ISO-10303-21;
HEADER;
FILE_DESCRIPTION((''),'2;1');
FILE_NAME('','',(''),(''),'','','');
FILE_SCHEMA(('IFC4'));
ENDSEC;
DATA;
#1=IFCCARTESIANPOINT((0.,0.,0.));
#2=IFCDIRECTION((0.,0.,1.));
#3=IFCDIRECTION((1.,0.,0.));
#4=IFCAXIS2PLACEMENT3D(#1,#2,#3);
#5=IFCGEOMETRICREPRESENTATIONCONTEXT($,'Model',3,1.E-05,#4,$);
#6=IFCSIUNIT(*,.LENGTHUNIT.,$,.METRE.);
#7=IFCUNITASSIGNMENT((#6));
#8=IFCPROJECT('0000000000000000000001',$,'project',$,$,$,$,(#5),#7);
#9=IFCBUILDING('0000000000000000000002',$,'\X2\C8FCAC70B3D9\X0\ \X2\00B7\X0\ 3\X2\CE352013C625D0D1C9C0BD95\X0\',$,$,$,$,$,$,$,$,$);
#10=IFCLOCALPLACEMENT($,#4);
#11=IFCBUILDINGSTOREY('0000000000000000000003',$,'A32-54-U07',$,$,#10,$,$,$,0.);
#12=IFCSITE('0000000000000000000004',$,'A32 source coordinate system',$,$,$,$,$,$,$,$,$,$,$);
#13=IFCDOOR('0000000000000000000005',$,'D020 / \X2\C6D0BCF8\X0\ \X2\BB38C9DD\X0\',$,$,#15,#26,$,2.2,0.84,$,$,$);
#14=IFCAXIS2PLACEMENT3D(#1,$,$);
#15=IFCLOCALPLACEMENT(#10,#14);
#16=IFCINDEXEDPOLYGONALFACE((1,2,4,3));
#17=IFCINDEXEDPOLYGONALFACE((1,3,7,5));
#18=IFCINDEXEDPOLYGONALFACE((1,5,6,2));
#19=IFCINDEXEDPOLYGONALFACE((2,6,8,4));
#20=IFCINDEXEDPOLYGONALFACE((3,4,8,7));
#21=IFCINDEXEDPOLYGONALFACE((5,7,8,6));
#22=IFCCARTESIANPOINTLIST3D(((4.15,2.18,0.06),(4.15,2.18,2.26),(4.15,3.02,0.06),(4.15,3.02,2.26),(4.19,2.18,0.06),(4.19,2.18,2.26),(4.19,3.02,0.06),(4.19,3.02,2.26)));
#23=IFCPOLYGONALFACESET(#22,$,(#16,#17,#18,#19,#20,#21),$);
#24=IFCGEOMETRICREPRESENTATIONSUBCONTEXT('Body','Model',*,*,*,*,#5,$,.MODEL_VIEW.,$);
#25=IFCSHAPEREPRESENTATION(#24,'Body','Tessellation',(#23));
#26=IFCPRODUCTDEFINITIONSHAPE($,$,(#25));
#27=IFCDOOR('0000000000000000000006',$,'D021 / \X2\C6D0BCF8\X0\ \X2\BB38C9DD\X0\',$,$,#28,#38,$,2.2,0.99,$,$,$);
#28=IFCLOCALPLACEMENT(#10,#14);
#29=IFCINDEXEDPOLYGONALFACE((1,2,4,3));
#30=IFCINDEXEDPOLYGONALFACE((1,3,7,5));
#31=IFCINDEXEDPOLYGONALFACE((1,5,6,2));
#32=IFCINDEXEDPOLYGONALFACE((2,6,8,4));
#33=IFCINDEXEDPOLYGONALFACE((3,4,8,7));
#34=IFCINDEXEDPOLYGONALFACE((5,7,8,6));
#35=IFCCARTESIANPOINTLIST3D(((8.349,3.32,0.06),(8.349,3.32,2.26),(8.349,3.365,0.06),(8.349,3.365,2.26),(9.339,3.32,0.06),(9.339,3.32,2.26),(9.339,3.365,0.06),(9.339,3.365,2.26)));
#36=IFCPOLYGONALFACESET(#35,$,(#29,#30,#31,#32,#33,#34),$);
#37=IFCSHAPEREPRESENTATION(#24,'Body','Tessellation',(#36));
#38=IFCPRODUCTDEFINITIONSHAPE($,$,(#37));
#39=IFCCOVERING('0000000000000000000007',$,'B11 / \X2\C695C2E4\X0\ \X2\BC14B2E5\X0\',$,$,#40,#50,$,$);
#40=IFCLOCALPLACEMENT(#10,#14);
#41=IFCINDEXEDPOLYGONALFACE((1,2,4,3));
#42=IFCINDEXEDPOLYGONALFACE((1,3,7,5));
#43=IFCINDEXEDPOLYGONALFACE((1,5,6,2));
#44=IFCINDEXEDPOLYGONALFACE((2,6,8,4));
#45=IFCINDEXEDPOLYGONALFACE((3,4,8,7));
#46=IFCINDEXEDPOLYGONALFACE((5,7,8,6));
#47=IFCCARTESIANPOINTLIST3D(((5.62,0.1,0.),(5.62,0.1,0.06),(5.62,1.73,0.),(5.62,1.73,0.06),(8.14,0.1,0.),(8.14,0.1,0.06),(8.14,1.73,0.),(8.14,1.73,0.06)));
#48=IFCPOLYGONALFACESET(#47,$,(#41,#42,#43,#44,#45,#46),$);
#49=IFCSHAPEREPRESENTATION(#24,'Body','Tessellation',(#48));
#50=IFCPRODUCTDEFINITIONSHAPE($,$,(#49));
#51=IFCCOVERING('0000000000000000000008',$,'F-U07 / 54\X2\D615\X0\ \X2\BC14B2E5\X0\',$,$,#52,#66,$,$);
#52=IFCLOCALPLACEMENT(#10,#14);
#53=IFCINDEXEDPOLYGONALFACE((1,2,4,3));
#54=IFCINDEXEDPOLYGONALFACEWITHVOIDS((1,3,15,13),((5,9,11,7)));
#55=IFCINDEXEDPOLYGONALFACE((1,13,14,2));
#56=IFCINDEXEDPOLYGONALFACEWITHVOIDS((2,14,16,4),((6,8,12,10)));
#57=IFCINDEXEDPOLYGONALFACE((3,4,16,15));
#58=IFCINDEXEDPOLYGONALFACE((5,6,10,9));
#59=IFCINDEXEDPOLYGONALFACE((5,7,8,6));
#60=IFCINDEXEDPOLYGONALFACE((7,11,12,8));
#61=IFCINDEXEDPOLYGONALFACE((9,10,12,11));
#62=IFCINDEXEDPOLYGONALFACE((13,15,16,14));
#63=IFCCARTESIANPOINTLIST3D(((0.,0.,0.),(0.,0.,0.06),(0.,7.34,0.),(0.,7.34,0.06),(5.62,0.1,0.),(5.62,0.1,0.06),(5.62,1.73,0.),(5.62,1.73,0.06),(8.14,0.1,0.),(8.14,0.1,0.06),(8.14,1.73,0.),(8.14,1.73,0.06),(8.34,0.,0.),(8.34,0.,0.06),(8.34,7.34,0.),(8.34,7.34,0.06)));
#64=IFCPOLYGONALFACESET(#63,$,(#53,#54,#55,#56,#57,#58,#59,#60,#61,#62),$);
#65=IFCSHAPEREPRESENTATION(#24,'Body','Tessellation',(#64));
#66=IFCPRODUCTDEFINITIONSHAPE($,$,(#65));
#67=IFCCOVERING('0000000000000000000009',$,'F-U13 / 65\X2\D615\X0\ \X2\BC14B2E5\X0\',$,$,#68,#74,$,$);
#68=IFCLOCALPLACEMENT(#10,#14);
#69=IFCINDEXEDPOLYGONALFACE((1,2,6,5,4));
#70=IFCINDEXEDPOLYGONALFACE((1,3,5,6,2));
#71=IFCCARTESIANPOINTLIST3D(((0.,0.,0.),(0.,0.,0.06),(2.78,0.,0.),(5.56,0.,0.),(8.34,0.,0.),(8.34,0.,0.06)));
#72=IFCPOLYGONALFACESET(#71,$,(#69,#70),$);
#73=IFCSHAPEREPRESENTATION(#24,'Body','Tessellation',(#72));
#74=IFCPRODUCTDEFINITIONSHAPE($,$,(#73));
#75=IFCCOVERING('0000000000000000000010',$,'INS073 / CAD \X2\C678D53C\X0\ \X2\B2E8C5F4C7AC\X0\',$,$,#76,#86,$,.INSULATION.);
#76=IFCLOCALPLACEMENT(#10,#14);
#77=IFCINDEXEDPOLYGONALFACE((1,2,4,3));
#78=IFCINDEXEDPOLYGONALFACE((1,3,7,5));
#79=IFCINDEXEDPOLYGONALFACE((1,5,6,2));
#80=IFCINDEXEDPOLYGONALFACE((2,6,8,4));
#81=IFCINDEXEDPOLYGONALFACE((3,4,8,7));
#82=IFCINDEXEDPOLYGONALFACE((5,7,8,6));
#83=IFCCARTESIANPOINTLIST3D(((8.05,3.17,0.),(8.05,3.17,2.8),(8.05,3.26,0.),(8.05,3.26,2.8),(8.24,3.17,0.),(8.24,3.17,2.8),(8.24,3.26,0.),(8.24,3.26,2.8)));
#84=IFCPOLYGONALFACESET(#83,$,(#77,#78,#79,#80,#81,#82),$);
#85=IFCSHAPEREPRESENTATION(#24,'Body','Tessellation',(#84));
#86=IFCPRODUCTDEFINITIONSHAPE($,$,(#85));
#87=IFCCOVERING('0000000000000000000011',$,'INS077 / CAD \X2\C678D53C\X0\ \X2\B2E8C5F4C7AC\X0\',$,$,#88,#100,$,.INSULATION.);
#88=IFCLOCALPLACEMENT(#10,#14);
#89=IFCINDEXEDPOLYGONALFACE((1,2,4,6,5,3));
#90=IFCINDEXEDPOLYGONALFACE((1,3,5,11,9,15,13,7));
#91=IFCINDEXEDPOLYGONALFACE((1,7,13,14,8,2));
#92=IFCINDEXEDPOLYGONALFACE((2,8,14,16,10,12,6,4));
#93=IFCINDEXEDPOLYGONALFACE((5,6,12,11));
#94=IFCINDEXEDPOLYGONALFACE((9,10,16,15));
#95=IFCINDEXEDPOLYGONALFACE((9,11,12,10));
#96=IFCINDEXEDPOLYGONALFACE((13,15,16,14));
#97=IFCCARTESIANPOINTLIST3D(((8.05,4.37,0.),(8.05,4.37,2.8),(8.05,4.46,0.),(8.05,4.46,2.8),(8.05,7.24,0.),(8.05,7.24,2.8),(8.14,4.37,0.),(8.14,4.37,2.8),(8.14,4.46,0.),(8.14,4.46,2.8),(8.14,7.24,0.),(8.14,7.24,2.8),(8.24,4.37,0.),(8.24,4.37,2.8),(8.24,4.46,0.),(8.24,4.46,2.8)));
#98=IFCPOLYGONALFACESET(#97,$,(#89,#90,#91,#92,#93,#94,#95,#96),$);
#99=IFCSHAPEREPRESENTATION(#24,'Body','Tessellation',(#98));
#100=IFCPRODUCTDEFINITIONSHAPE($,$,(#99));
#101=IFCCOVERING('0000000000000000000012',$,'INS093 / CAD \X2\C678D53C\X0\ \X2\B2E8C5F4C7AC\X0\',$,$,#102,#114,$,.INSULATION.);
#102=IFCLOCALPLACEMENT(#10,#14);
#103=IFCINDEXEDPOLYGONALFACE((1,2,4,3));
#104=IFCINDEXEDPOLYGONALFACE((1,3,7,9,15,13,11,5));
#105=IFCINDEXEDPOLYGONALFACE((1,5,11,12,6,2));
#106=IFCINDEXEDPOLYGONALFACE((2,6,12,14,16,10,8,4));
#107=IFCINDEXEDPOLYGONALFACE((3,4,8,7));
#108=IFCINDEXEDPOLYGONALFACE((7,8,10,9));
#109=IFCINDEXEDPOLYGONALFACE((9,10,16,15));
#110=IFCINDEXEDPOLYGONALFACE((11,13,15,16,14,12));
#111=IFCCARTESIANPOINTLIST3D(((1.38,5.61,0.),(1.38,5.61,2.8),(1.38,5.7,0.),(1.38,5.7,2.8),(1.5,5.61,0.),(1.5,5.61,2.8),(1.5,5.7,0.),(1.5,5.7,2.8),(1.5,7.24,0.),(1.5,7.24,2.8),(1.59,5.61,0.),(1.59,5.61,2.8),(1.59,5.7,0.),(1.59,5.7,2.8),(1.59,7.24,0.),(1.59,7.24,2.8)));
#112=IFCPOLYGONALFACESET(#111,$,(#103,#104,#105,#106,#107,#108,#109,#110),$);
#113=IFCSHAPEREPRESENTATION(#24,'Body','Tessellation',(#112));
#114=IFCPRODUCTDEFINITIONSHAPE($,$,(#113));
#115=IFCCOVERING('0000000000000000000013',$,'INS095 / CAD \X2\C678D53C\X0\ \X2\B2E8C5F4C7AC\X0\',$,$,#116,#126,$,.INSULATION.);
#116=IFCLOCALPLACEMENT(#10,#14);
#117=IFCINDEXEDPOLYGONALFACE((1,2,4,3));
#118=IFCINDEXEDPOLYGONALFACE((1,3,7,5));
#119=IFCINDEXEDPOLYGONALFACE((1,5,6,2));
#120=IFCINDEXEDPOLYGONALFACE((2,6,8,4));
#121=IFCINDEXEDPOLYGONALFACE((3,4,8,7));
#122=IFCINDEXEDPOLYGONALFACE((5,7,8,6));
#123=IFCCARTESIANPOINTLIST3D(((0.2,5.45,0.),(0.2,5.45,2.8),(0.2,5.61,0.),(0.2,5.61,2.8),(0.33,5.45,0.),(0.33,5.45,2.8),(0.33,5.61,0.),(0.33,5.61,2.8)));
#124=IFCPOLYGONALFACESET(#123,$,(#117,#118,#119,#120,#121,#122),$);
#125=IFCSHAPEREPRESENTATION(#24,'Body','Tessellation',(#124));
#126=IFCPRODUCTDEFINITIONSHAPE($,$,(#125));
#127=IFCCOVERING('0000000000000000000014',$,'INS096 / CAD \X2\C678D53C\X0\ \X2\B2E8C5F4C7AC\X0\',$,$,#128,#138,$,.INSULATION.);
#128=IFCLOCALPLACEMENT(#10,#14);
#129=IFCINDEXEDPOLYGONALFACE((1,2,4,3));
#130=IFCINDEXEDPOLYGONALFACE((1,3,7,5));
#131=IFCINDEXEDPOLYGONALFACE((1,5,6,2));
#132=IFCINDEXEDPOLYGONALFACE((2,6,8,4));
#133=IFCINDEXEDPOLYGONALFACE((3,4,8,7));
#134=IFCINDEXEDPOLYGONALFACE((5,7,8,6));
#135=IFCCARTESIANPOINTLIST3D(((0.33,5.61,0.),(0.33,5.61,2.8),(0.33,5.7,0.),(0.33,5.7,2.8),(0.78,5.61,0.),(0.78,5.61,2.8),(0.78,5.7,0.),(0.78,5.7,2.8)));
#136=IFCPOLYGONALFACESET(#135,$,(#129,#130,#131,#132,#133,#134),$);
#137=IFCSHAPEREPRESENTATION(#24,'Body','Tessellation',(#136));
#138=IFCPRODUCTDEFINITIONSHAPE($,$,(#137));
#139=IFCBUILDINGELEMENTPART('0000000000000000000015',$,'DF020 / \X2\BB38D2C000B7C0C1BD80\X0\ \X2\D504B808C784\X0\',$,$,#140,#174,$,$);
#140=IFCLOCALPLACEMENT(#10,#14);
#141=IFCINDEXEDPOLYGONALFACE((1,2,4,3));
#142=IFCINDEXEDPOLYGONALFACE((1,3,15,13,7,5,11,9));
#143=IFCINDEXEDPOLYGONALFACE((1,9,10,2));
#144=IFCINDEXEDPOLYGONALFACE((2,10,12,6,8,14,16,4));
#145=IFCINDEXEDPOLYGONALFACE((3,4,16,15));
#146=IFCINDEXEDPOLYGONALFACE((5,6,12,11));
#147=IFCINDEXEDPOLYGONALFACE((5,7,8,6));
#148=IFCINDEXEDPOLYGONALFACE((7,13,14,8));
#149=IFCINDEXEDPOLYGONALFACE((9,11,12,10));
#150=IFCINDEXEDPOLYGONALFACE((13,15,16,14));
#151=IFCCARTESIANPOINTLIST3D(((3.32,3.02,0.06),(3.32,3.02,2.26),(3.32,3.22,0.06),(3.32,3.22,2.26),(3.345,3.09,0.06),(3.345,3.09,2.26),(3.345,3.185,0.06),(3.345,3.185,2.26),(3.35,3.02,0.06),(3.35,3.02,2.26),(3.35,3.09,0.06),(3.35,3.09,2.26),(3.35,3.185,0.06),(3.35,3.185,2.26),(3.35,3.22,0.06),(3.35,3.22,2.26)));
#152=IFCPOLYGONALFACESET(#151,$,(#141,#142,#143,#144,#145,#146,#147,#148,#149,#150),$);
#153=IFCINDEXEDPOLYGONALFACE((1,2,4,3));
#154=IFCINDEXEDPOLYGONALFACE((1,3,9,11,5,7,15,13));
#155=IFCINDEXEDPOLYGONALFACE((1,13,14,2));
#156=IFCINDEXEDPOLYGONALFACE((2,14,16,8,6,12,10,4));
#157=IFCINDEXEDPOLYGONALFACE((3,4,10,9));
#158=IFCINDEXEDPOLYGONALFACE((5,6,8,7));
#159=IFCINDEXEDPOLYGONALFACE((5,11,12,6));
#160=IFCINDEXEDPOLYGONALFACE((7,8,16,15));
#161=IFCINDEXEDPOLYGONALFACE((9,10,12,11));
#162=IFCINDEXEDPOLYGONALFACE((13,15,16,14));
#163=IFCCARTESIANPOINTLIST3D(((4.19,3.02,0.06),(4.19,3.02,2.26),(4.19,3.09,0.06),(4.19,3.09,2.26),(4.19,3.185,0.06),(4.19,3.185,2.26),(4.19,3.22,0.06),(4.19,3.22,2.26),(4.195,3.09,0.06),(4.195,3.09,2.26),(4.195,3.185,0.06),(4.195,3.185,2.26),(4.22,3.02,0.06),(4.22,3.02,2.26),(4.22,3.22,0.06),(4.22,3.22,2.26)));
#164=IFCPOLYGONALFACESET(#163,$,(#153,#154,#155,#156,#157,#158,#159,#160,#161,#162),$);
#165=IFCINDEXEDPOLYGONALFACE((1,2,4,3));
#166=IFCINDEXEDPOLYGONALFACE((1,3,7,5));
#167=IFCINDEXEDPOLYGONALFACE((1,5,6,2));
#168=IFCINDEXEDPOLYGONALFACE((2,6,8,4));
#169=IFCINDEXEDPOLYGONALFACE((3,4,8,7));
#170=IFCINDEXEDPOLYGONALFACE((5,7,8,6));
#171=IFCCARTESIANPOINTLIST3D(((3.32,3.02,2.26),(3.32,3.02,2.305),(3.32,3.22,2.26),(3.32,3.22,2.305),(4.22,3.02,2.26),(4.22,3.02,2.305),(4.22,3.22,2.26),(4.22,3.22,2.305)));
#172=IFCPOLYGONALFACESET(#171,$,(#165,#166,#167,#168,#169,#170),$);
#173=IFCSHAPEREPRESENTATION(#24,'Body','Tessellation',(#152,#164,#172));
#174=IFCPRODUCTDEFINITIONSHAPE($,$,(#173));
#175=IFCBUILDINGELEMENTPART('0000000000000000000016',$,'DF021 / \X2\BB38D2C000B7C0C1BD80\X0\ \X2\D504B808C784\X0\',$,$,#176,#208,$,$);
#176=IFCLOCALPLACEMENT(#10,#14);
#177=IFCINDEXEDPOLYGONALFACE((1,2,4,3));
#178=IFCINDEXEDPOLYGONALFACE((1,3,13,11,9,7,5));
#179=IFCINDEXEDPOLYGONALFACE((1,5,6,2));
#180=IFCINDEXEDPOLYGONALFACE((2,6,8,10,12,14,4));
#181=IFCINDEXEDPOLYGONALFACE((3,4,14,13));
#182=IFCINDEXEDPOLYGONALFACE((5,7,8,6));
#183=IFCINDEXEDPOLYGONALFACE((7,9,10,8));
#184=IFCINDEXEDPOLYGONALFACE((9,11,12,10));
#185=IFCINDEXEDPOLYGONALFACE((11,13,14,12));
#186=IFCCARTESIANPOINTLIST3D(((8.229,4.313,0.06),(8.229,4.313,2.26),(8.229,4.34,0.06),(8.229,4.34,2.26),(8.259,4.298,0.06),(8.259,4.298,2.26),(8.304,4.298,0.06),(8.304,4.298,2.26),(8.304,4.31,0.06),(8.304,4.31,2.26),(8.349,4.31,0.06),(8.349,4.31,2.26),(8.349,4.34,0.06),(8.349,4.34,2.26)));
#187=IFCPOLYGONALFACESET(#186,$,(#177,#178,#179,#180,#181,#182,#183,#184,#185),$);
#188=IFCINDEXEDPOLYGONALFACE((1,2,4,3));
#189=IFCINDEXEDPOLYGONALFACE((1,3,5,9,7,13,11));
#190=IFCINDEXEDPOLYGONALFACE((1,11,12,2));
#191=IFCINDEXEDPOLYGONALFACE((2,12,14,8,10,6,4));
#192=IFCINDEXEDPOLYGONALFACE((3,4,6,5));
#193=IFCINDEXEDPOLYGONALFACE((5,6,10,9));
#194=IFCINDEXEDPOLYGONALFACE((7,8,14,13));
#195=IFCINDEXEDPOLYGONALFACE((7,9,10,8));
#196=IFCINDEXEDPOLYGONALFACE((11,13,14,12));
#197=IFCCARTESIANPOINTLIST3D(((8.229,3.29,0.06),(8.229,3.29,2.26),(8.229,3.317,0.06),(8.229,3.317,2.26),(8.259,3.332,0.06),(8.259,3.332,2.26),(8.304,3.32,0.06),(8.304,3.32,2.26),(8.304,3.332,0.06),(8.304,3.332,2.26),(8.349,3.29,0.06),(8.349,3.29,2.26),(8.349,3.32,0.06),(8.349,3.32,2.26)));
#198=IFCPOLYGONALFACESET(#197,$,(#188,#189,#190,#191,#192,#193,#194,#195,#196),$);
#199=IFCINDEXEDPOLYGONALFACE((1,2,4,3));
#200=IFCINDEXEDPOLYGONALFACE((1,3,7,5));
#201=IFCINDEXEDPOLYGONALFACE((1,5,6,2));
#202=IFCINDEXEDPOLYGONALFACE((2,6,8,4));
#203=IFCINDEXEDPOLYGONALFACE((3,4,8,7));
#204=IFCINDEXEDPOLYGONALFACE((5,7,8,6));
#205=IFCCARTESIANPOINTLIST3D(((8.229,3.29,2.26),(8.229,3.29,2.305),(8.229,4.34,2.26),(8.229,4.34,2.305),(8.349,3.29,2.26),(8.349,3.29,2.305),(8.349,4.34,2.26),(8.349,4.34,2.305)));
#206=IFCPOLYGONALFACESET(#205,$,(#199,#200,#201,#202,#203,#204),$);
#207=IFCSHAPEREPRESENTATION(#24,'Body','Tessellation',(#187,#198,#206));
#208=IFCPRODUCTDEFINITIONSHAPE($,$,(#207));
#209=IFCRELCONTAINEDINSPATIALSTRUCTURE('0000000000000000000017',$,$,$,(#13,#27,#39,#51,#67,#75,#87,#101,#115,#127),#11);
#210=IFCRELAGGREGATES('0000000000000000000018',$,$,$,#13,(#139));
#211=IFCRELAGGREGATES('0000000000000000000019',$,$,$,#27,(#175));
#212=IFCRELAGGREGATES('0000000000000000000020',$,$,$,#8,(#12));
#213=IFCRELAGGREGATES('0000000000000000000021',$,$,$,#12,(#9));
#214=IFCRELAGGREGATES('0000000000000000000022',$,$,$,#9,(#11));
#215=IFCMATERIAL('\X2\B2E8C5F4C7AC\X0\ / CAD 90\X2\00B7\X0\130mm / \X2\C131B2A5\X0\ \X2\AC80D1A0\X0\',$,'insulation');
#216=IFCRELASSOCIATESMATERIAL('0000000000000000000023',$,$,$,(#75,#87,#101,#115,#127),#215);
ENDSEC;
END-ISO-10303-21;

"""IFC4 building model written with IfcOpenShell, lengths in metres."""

from ifc_helpers import new_model, si_unit, frame, origin, origin_with_axes, place, context, subcontext, project, spatial, polyline, outline, extrude, material, element, aggregate, save


model = new_model("IFC4")

# Units and contexts
model_context = context("Model", 3, precision=1e-05, world=origin_with_axes())
body_context = subcontext(model_context, "Body", "Model", "MODEL_VIEW")
ifc_project = project(units=[si_unit("LENGTHUNIT", "METRE")], contexts=[model_context])

# Site, building, storey
storey_placement = place(None, origin_with_axes())
site = spatial("IfcSite", under=ifc_project, Name="A32 source coordinate system")
building = spatial("IfcBuilding", under=site, Name="주거동 · 3층–옥탑지붕")
storey = spatial("IfcBuildingStorey", under=building, at=storey_placement, Name="A32-54-U07", Elevation=0.0)

# Doors
door_1_placement = place(storey_placement, origin_with_axes())
door_1 = element("IfcDoor", 1, at=door_1_placement, inside=storey, Name="D020 / 원본 문짝", OverallHeight=2.2, OverallWidth=0.84, context=body_context, shape_type="SweptSolid", body=[
    extrude(outline(polyline([(4.19, 3.02), (4.19, 2.18), (4.15, 2.18), (4.15, 3.02), (4.19, 3.02)])), frame((0.0, 0.0, 0.06)), (0.0, 0.0, 1.0), 2.2),
])
door_2_placement = place(storey_placement, origin_with_axes())
door_2 = element("IfcDoor", 2, at=door_2_placement, inside=storey, Name="D021 / 원본 문짝", OverallHeight=2.2, OverallWidth=0.99, context=body_context, shape_type="SweptSolid", body=[
    extrude(outline(polyline([(9.339, 3.365), (9.339, 3.32), (8.349, 3.32), (8.349, 3.365), (9.339, 3.365)])), frame((0.0, 0.0, 0.06)), (0.0, 0.0, 1.0), 2.2),
])

# Coverings
covering_1_placement = place(storey_placement, origin_with_axes())
element("IfcCovering", 3, at=covering_1_placement, inside=storey, Name="B11 / 욕실 바닥", context=body_context, shape_type="SweptSolid", body=[
    extrude(outline(polyline([(8.14, 1.73), (8.14, 0.1), (5.62, 0.1), (5.62, 1.73), (8.14, 1.73)])), origin(), (0.0, 0.0, 1.0), 0.06),
])
covering_2_placement = place(storey_placement, origin_with_axes())
element("IfcCovering", 4, at=covering_2_placement, inside=storey, Name="F-U07 / 54형 바닥", context=body_context, shape_type="SweptSolid", body=[
    extrude(outline(polyline([(0.0, 0.0), (0.0, 7.34), (8.34, 7.34), (8.34, 0.0), (0.0, 0.0)]), holes=[polyline([(5.62, 1.73), (5.62, 0.1), (8.14, 0.1), (8.14, 1.73), (5.62, 1.73)])]), origin(), (0.0, 0.0, 1.0), 0.06),
])
covering_3_placement = place(storey_placement, origin_with_axes())
element("IfcCovering", 5, at=covering_3_placement, inside=storey, Name="F-U13 / 65형 바닥", context=body_context, shape_type="SweptSolid", body=[
    extrude(outline(polyline([(0.0, 0.0), (8.34, 0.0), (8.34, 0.0), (0.0, 0.0), (0.0, 0.0)])), origin(), (0.0, 0.0, 1.0), 0.06),
])
ifc_material = material(Name="단열재 / CAD 90·130mm / 성능 검토", Category="insulation")
covering_4_placement = place(storey_placement, origin_with_axes())
element("IfcCovering", 6, at=covering_4_placement, inside=storey, material=ifc_material, Name="INS073 / CAD 외피 단열재", PredefinedType="INSULATION", context=body_context, shape_type="SweptSolid", body=[
    extrude(outline(polyline([(8.05, 3.17), (8.05, 3.26), (8.24, 3.26), (8.24, 3.17), (8.05, 3.17)])), origin(), (0.0, 0.0, 1.0), 2.8),
])
covering_5_placement = place(storey_placement, origin_with_axes())
element("IfcCovering", 7, at=covering_5_placement, inside=storey, material=ifc_material, Name="INS077 / CAD 외피 단열재", PredefinedType="INSULATION", context=body_context, shape_type="SweptSolid", body=[
    extrude(outline(polyline([(8.24, 4.37), (8.14, 4.37), (8.05, 4.37), (8.05, 4.46), (8.05, 7.24), (8.14, 7.24), (8.14, 4.46), (8.24, 4.46), (8.24, 4.37)])), origin(), (0.0, 0.0, 1.0), 2.8),
])
covering_6_placement = place(storey_placement, origin_with_axes())
element("IfcCovering", 8, at=covering_6_placement, inside=storey, material=ifc_material, Name="INS093 / CAD 외피 단열재", PredefinedType="INSULATION", context=body_context, shape_type="SweptSolid", body=[
    extrude(outline(polyline([(1.5, 5.7), (1.5, 7.24), (1.59, 7.24), (1.59, 5.7), (1.59, 5.61), (1.5, 5.61), (1.38, 5.61), (1.38, 5.7), (1.5, 5.7)])), origin(), (0.0, 0.0, 1.0), 2.8),
])
covering_7_placement = place(storey_placement, origin_with_axes())
element("IfcCovering", 9, at=covering_7_placement, inside=storey, material=ifc_material, Name="INS095 / CAD 외피 단열재", PredefinedType="INSULATION", context=body_context, shape_type="SweptSolid", body=[
    extrude(outline(polyline([(0.2, 5.61), (0.33, 5.61), (0.33, 5.45), (0.2, 5.45), (0.2, 5.61)])), origin(), (0.0, 0.0, 1.0), 2.8),
])
covering_8_placement = place(storey_placement, origin_with_axes())
element("IfcCovering", 10, at=covering_8_placement, inside=storey, material=ifc_material, Name="INS096 / CAD 외피 단열재", PredefinedType="INSULATION", context=body_context, shape_type="SweptSolid", body=[
    extrude(outline(polyline([(0.78, 5.7), (0.78, 5.61), (0.33, 5.61), (0.33, 5.7), (0.78, 5.7)])), origin(), (0.0, 0.0, 1.0), 2.8),
])

# Building element parts
building_element_part_1_placement = place(door_1_placement, origin_with_axes())
building_element_part_1 = element("IfcBuildingElementPart", 11, at=building_element_part_1_placement, Name="DF020 / 문틀·상부 프레임", context=body_context, shape_type="SweptSolid", body=[
    extrude(outline(polyline([(3.32, 3.22), (3.35, 3.22), (3.35, 3.185), (3.345, 3.185), (3.345, 3.09), (3.35, 3.09), (3.35, 3.02), (3.32, 3.02), (3.32, 3.22)])), frame((0.0, 0.0, 0.06)), (0.0, 0.0, 1.0), 2.2),
    extrude(outline(polyline([(4.19, 3.02), (4.19, 3.09), (4.195, 3.09), (4.195, 3.185), (4.19, 3.185), (4.19, 3.22), (4.22, 3.22), (4.22, 3.02), (4.19, 3.02)])), frame((0.0, 0.0, 0.06)), (0.0, 0.0, 1.0), 2.2),
    extrude(outline(polyline([(3.32, 3.02), (3.32, 3.22), (4.22, 3.22), (4.22, 3.02), (3.32, 3.02)])), frame((0.0, 0.0, 2.26)), (0.0, 0.0, 1.0), 0.045),
])
aggregate(door_1, [building_element_part_1])
building_element_part_2_placement = place(door_2_placement, origin_with_axes())
building_element_part_2 = element("IfcBuildingElementPart", 12, at=building_element_part_2_placement, Name="DF021 / 문틀·상부 프레임", context=body_context, shape_type="SweptSolid", body=[
    extrude(outline(polyline([(8.349, 4.31), (8.304, 4.31), (8.304, 4.298), (8.259, 4.298), (8.229, 4.313), (8.229, 4.34), (8.349, 4.34), (8.349, 4.31)])), frame((0.0, 0.0, 0.06)), (0.0, 0.0, 1.0), 2.2),
    extrude(outline(polyline([(8.229, 3.29), (8.229, 3.317), (8.259, 3.332), (8.304, 3.332), (8.304, 3.32), (8.349, 3.32), (8.349, 3.29), (8.229, 3.29)])), frame((0.0, 0.0, 0.06)), (0.0, 0.0, 1.0), 2.2),
    extrude(outline(polyline([(8.229, 3.29), (8.229, 4.34), (8.349, 4.34), (8.349, 3.29), (8.229, 3.29)])), frame((0.0, 0.0, 2.26)), (0.0, 0.0, 1.0), 0.045),
])
aggregate(door_2, [building_element_part_2])

save(model, "model.ifc")
